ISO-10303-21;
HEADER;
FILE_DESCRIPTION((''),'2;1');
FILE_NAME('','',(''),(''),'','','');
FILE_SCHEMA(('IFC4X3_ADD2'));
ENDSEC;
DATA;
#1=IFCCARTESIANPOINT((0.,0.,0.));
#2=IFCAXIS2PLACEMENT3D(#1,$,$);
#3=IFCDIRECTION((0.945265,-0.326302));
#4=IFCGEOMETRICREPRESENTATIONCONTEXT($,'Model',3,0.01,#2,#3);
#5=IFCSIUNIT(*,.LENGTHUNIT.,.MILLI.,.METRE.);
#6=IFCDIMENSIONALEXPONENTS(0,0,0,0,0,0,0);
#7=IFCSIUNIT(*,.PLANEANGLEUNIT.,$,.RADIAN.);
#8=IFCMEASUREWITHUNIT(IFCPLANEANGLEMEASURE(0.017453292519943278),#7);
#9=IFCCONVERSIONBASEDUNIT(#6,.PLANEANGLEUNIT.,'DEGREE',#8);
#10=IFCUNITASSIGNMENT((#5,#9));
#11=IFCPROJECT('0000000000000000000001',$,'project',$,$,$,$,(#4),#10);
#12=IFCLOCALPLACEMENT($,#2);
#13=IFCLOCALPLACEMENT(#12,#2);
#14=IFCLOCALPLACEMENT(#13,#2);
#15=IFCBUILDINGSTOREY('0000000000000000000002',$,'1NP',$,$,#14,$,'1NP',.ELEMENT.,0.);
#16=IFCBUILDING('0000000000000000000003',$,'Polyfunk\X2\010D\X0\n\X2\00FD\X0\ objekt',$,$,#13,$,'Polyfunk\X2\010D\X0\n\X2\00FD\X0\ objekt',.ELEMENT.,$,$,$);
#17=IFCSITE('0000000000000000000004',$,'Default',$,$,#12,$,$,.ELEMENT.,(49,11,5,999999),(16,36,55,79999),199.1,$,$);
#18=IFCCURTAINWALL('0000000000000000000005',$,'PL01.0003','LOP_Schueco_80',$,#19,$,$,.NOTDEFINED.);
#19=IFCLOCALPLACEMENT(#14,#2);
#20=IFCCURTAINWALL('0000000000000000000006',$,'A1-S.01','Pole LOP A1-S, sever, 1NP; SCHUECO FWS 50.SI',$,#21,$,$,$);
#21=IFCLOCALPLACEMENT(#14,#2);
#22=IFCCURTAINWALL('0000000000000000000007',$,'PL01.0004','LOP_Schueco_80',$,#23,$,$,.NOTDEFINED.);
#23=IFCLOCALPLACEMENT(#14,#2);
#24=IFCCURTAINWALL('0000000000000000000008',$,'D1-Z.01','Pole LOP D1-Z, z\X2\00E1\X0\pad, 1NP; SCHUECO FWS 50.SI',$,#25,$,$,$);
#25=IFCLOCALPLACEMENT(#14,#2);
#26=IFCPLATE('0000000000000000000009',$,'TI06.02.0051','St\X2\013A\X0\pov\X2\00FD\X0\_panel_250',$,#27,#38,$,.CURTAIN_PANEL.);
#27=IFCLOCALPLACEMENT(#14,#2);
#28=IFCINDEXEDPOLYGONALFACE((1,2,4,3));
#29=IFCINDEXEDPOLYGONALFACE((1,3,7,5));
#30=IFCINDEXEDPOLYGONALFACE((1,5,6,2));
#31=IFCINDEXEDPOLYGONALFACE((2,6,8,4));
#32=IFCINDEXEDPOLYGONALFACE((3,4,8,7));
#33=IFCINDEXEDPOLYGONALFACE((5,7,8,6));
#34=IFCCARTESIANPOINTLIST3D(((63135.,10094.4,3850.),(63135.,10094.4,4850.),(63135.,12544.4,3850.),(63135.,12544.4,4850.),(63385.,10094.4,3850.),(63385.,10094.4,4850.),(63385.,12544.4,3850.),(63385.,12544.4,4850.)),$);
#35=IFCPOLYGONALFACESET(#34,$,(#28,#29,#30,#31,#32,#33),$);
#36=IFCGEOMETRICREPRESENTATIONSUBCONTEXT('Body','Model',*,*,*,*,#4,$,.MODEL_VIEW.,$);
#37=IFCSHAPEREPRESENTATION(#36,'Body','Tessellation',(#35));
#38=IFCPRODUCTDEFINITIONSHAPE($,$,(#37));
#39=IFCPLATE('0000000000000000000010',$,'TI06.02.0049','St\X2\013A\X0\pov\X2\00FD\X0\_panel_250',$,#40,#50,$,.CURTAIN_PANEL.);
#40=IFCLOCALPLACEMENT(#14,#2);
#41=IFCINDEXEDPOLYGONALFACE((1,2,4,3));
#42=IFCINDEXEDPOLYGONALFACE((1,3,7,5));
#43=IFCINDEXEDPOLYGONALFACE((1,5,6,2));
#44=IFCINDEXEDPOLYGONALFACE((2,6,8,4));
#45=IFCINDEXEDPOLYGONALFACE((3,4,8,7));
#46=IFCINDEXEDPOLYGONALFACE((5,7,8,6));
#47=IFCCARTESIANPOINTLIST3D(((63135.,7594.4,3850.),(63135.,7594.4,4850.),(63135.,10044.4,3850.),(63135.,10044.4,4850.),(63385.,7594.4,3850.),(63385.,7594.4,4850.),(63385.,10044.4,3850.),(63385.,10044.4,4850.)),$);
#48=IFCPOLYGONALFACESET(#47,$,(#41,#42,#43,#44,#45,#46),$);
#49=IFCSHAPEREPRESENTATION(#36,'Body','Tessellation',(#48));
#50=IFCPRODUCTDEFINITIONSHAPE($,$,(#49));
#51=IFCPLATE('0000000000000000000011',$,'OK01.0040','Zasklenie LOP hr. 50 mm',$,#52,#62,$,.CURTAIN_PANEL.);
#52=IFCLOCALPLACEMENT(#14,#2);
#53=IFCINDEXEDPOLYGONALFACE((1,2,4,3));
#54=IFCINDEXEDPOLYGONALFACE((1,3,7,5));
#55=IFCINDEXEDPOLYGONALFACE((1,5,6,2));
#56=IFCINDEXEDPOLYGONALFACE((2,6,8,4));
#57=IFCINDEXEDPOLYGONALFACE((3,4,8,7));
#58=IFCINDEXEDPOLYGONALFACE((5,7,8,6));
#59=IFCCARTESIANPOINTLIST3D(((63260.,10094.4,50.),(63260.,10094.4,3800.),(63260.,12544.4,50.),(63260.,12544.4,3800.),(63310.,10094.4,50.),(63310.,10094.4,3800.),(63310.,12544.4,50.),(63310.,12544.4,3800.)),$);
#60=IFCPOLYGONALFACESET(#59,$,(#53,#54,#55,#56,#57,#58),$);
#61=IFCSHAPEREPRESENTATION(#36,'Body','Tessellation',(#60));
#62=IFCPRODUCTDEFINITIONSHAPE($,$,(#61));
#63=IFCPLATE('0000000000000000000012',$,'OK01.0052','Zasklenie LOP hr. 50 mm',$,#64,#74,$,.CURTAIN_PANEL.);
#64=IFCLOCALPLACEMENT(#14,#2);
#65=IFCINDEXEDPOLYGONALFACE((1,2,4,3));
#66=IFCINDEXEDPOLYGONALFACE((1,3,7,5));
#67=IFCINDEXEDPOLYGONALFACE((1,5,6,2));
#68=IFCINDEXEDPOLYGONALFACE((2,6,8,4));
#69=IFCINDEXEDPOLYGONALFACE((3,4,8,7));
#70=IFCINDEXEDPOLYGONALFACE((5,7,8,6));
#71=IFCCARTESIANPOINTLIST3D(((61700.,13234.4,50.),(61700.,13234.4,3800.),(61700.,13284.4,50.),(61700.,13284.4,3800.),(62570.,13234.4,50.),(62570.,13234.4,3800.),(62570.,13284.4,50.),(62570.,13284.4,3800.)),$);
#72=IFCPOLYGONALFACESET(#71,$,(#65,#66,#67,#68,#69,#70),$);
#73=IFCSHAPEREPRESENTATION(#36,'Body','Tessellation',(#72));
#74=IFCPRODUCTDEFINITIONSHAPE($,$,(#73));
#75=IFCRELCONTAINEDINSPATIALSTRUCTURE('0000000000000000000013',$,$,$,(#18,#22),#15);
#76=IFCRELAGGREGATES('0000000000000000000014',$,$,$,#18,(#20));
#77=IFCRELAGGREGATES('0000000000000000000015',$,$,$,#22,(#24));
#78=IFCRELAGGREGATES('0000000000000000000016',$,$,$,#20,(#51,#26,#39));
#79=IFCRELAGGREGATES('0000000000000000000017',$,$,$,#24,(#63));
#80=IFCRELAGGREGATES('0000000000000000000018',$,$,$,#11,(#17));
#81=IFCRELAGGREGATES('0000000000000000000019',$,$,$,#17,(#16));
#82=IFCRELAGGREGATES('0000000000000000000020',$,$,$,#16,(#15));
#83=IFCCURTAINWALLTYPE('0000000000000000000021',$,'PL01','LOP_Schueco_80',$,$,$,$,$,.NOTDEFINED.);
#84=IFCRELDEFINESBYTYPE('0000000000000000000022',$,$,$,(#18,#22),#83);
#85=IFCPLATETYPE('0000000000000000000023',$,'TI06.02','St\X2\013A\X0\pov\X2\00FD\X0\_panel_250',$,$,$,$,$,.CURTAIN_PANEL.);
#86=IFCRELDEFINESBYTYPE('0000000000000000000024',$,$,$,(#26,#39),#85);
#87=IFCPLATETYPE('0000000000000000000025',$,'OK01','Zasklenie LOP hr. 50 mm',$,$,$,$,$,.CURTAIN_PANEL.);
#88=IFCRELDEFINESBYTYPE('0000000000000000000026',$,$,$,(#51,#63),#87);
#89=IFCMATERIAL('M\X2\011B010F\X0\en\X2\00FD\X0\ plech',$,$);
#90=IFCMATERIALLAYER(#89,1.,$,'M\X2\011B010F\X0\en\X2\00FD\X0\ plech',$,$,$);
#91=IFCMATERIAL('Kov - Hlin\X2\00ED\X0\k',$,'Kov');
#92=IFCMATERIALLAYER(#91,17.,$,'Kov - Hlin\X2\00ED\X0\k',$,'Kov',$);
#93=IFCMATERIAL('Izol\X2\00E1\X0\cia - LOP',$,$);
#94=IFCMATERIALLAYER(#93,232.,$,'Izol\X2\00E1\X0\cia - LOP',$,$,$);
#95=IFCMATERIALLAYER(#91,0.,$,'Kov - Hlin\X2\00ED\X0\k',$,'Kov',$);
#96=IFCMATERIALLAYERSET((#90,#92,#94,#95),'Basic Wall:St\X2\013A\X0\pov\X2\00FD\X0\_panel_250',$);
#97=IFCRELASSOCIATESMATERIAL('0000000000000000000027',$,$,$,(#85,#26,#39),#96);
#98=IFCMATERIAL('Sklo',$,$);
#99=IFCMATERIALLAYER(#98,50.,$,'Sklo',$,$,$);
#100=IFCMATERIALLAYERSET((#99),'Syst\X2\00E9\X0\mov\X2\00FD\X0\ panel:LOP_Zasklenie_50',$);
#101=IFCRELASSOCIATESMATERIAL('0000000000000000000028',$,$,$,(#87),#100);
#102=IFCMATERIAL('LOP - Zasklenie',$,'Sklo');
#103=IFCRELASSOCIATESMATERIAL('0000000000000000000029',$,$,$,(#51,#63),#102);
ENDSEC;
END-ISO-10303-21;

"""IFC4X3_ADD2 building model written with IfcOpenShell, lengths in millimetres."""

from ifc_helpers import new_model, entity, si_unit, converted_unit, direction, frame, frame_2d, origin, place, context, subcontext, project, spatial, rectangle, extrude, source, transform, mapped, material, layer, layer_set, layer_usage, type_object, type_shapes, element, aggregate, save


model = new_model("IFC4X3_ADD2")

# Units and contexts
model_context = context("Model", 3, precision=0.01, world=origin(), true_north=direction((0.945265, -0.326302)))
body_context = subcontext(model_context, "Body", "Model", "MODEL_VIEW")
ifc_project = project(units=[si_unit("LENGTHUNIT", "METRE", prefix="MILLI"), converted_unit("PLANEANGLEUNIT", "DEGREE", entity("IfcPlaneAngleMeasure", 0.017453292519943278), si_unit("PLANEANGLEUNIT", "RADIAN"), dimensions=[0, 0, 0, 0, 0, 0, 0])], contexts=[model_context])

# Site, building, storey
site_placement = place(None, origin())
site = spatial("IfcSite", under=ifc_project, at=site_placement, Name="Default", CompositionType="ELEMENT", RefLatitude=(49, 11, 5, 999999), RefLongitude=(16, 36, 55, 79999), RefElevation=199.1)
building_placement = place(site_placement, origin())
building = spatial("IfcBuilding", under=site, at=building_placement, Name="Polyfunkčný objekt", LongName="Polyfunkčný objekt", CompositionType="ELEMENT")
storey_placement = place(building_placement, origin())
storey = spatial("IfcBuildingStorey", under=building, at=storey_placement, Name="1NP", LongName="1NP", CompositionType="ELEMENT", Elevation=0.0)

# Curtain walls
curtain_wall_type = type_object("IfcCurtainWallType", Name="PL01", Description="LOP_Schueco_80", PredefinedType="NOTDEFINED")
curtain_wall_1_placement = place(storey_placement, origin())
curtain_wall_1 = element("IfcCurtainWall", 1, at=curtain_wall_1_placement, inside=storey, type_object=curtain_wall_type, Name="PL01.0003", Description="LOP_Schueco_80", PredefinedType="NOTDEFINED")
curtain_wall_2 = element("IfcCurtainWall", 2, Name="A1-S.01", Description="Pole LOP A1-S, sever, 1NP; SCHUECO FWS 50.SI")
aggregate(curtain_wall_1, [curtain_wall_2])

# Curtain walls
curtain_wall_3_placement = place(storey_placement, origin())
curtain_wall_3 = element("IfcCurtainWall", 3, at=curtain_wall_3_placement, inside=storey, type_object=curtain_wall_type, Name="PL01.0004", Description="LOP_Schueco_80", PredefinedType="NOTDEFINED")
curtain_wall_4 = element("IfcCurtainWall", 4, Name="D1-Z.01", Description="Pole LOP D1-Z, západ, 1NP; SCHUECO FWS 50.SI")
aggregate(curtain_wall_3, [curtain_wall_4])

# Plates
ifc_material_1 = material(Name="Měďený plech")
ifc_layer_1 = layer(ifc_material_1, 1.0, Name="Měďený plech")
ifc_material_2 = material(Name="Kov - Hliník", Category="Kov")
ifc_layer_2 = layer(ifc_material_2, 17.0, Name="Kov - Hliník", Category="Kov")
ifc_material_3 = material(Name="Izolácia - LOP")
ifc_layer_3 = layer(ifc_material_3, 232.0, Name="Izolácia - LOP")
ifc_layer_4 = layer(ifc_material_2, 0.0, Name="Kov - Hliník", Category="Kov")
ifc_layer_set_1 = layer_set([ifc_layer_1, ifc_layer_2, ifc_layer_3, ifc_layer_4], Name="Basic Wall:Stĺpový_panel_250")
ifc_layer_usage_1 = layer_usage(ifc_layer_set_1, "AXIS2", "NEGATIVE", 125.0)
plate_type_1 = type_object("IfcPlateType", Name="TI06.02", Description="Stĺpový_panel_250", PredefinedType="CURTAIN_PANEL", material=ifc_layer_set_1)
plate_1_placement = place(storey_placement, frame((63260.0, 12544.4, 3850.0), z_axis=(0.0, 0.0, 1.0), x_axis=(0.0, -1.0, 0.0)))
plate_1 = element("IfcPlate", 5, at=plate_1_placement, type_object=plate_type_1, material=ifc_layer_usage_1, Name="TI06.02.0051", Description="Stĺpový_panel_250", PredefinedType="CURTAIN_PANEL", context=body_context, shape_type="SweptSolid", body=[
    extrude(rectangle(XDim=250.0, YDim=2450.0, at=frame_2d((0.0, 0.0), x_axis=(1.0, 0.0))), frame((1225.0, 0.0, 0.0), z_axis=(0.0, 0.0, 1.0), x_axis=(0.0, 1.0, 0.0)), (0.0, 0.0, 1.0), 1000.0),
])
ifc_layer_usage_2 = layer_usage(ifc_layer_set_1, "AXIS2", "NEGATIVE", 125.0)
plate_2_placement = place(storey_placement, frame((63260.0, 10044.4, 3850.0), z_axis=(0.0, 0.0, 1.0), x_axis=(0.0, -1.0, 0.0)))
plate_2 = element("IfcPlate", 6, at=plate_2_placement, type_object=plate_type_1, material=ifc_layer_usage_2, Name="TI06.02.0049", Description="Stĺpový_panel_250", PredefinedType="CURTAIN_PANEL", context=body_context, shape_type="SweptSolid", body=[
    extrude(rectangle(XDim=250.0, YDim=2450.0, at=frame_2d((0.0, 0.0), x_axis=(1.0, 0.0))), frame((1225.0, 0.0, 0.0), z_axis=(0.0, 0.0, 1.0), x_axis=(0.0, 1.0, 0.0)), (0.0, 0.0, 1.0), 1000.0),
])
ifc_material_4 = material(Name="LOP - Zasklenie", Category="Sklo")
ifc_material_5 = material(Name="Sklo")
ifc_layer_5 = layer(ifc_material_5, 50.0, Name="Sklo")
ifc_layer_set_2 = layer_set([ifc_layer_5], Name="Systémový panel:LOP_Zasklenie_50")
plate_type_2 = type_object("IfcPlateType", Name="OK01", Description="Zasklenie LOP hr. 50 mm", PredefinedType="CURTAIN_PANEL", material=ifc_layer_set_2)
shared_shape_1 = source(origin(), body_context, "Body", "SweptSolid", [
    extrude(rectangle(XDim=3750.0, YDim=2450.0, at=frame_2d((-141.7, 0.0), x_axis=(1.0, 0.0))), frame((0.0, 0.0, 2016.7), z_axis=(0.0, 1.0, 0.0), x_axis=(0.0, 0.0, 1.0)), (0.0, 0.0, 1.0), 50.0),
])
plate_3_placement = place(curtain_wall_1_placement, frame((63260.0, 11319.4, 50.0), z_axis=(0.0, 0.0, 1.0), x_axis=(0.0, -1.0, 0.0)))
plate_3 = element("IfcPlate", 7, at=plate_3_placement, type_object=plate_type_2, material=ifc_material_4, Name="OK01.0040", Description="Zasklenie LOP hr. 50 mm", PredefinedType="CURTAIN_PANEL", context=body_context, shape_type="MappedRepresentation", body=[
    mapped(shared_shape_1, transform((0.0, 0.0, 0.0), scale=1.0)),
])
aggregate(curtain_wall_2, [plate_3, plate_1, plate_2])
shared_shape_2 = source(origin(), body_context, "Body", "SweptSolid", [
    extrude(rectangle(XDim=3750.0, YDim=870.0, at=frame_2d((-141.7, 0.0), x_axis=(1.0, 0.0))), frame((0.0, 0.0, 2016.7), z_axis=(0.0, 1.0, 0.0), x_axis=(0.0, 0.0, 1.0)), (0.0, 0.0, 1.0), 50.0),
])
type_shapes(plate_type_2, [shared_shape_1, shared_shape_2])
plate_4_placement = place(curtain_wall_3_placement, frame((62135.0, 13234.4, 50.0)))
plate_4 = element("IfcPlate", 8, at=plate_4_placement, type_object=plate_type_2, material=ifc_material_4, Name="OK01.0052", Description="Zasklenie LOP hr. 50 mm", PredefinedType="CURTAIN_PANEL", context=body_context, shape_type="MappedRepresentation", body=[
    mapped(shared_shape_2, transform((0.0, 0.0, 0.0), scale=1.0)),
])
aggregate(curtain_wall_4, [plate_4])

save(model, "model.ifc")
